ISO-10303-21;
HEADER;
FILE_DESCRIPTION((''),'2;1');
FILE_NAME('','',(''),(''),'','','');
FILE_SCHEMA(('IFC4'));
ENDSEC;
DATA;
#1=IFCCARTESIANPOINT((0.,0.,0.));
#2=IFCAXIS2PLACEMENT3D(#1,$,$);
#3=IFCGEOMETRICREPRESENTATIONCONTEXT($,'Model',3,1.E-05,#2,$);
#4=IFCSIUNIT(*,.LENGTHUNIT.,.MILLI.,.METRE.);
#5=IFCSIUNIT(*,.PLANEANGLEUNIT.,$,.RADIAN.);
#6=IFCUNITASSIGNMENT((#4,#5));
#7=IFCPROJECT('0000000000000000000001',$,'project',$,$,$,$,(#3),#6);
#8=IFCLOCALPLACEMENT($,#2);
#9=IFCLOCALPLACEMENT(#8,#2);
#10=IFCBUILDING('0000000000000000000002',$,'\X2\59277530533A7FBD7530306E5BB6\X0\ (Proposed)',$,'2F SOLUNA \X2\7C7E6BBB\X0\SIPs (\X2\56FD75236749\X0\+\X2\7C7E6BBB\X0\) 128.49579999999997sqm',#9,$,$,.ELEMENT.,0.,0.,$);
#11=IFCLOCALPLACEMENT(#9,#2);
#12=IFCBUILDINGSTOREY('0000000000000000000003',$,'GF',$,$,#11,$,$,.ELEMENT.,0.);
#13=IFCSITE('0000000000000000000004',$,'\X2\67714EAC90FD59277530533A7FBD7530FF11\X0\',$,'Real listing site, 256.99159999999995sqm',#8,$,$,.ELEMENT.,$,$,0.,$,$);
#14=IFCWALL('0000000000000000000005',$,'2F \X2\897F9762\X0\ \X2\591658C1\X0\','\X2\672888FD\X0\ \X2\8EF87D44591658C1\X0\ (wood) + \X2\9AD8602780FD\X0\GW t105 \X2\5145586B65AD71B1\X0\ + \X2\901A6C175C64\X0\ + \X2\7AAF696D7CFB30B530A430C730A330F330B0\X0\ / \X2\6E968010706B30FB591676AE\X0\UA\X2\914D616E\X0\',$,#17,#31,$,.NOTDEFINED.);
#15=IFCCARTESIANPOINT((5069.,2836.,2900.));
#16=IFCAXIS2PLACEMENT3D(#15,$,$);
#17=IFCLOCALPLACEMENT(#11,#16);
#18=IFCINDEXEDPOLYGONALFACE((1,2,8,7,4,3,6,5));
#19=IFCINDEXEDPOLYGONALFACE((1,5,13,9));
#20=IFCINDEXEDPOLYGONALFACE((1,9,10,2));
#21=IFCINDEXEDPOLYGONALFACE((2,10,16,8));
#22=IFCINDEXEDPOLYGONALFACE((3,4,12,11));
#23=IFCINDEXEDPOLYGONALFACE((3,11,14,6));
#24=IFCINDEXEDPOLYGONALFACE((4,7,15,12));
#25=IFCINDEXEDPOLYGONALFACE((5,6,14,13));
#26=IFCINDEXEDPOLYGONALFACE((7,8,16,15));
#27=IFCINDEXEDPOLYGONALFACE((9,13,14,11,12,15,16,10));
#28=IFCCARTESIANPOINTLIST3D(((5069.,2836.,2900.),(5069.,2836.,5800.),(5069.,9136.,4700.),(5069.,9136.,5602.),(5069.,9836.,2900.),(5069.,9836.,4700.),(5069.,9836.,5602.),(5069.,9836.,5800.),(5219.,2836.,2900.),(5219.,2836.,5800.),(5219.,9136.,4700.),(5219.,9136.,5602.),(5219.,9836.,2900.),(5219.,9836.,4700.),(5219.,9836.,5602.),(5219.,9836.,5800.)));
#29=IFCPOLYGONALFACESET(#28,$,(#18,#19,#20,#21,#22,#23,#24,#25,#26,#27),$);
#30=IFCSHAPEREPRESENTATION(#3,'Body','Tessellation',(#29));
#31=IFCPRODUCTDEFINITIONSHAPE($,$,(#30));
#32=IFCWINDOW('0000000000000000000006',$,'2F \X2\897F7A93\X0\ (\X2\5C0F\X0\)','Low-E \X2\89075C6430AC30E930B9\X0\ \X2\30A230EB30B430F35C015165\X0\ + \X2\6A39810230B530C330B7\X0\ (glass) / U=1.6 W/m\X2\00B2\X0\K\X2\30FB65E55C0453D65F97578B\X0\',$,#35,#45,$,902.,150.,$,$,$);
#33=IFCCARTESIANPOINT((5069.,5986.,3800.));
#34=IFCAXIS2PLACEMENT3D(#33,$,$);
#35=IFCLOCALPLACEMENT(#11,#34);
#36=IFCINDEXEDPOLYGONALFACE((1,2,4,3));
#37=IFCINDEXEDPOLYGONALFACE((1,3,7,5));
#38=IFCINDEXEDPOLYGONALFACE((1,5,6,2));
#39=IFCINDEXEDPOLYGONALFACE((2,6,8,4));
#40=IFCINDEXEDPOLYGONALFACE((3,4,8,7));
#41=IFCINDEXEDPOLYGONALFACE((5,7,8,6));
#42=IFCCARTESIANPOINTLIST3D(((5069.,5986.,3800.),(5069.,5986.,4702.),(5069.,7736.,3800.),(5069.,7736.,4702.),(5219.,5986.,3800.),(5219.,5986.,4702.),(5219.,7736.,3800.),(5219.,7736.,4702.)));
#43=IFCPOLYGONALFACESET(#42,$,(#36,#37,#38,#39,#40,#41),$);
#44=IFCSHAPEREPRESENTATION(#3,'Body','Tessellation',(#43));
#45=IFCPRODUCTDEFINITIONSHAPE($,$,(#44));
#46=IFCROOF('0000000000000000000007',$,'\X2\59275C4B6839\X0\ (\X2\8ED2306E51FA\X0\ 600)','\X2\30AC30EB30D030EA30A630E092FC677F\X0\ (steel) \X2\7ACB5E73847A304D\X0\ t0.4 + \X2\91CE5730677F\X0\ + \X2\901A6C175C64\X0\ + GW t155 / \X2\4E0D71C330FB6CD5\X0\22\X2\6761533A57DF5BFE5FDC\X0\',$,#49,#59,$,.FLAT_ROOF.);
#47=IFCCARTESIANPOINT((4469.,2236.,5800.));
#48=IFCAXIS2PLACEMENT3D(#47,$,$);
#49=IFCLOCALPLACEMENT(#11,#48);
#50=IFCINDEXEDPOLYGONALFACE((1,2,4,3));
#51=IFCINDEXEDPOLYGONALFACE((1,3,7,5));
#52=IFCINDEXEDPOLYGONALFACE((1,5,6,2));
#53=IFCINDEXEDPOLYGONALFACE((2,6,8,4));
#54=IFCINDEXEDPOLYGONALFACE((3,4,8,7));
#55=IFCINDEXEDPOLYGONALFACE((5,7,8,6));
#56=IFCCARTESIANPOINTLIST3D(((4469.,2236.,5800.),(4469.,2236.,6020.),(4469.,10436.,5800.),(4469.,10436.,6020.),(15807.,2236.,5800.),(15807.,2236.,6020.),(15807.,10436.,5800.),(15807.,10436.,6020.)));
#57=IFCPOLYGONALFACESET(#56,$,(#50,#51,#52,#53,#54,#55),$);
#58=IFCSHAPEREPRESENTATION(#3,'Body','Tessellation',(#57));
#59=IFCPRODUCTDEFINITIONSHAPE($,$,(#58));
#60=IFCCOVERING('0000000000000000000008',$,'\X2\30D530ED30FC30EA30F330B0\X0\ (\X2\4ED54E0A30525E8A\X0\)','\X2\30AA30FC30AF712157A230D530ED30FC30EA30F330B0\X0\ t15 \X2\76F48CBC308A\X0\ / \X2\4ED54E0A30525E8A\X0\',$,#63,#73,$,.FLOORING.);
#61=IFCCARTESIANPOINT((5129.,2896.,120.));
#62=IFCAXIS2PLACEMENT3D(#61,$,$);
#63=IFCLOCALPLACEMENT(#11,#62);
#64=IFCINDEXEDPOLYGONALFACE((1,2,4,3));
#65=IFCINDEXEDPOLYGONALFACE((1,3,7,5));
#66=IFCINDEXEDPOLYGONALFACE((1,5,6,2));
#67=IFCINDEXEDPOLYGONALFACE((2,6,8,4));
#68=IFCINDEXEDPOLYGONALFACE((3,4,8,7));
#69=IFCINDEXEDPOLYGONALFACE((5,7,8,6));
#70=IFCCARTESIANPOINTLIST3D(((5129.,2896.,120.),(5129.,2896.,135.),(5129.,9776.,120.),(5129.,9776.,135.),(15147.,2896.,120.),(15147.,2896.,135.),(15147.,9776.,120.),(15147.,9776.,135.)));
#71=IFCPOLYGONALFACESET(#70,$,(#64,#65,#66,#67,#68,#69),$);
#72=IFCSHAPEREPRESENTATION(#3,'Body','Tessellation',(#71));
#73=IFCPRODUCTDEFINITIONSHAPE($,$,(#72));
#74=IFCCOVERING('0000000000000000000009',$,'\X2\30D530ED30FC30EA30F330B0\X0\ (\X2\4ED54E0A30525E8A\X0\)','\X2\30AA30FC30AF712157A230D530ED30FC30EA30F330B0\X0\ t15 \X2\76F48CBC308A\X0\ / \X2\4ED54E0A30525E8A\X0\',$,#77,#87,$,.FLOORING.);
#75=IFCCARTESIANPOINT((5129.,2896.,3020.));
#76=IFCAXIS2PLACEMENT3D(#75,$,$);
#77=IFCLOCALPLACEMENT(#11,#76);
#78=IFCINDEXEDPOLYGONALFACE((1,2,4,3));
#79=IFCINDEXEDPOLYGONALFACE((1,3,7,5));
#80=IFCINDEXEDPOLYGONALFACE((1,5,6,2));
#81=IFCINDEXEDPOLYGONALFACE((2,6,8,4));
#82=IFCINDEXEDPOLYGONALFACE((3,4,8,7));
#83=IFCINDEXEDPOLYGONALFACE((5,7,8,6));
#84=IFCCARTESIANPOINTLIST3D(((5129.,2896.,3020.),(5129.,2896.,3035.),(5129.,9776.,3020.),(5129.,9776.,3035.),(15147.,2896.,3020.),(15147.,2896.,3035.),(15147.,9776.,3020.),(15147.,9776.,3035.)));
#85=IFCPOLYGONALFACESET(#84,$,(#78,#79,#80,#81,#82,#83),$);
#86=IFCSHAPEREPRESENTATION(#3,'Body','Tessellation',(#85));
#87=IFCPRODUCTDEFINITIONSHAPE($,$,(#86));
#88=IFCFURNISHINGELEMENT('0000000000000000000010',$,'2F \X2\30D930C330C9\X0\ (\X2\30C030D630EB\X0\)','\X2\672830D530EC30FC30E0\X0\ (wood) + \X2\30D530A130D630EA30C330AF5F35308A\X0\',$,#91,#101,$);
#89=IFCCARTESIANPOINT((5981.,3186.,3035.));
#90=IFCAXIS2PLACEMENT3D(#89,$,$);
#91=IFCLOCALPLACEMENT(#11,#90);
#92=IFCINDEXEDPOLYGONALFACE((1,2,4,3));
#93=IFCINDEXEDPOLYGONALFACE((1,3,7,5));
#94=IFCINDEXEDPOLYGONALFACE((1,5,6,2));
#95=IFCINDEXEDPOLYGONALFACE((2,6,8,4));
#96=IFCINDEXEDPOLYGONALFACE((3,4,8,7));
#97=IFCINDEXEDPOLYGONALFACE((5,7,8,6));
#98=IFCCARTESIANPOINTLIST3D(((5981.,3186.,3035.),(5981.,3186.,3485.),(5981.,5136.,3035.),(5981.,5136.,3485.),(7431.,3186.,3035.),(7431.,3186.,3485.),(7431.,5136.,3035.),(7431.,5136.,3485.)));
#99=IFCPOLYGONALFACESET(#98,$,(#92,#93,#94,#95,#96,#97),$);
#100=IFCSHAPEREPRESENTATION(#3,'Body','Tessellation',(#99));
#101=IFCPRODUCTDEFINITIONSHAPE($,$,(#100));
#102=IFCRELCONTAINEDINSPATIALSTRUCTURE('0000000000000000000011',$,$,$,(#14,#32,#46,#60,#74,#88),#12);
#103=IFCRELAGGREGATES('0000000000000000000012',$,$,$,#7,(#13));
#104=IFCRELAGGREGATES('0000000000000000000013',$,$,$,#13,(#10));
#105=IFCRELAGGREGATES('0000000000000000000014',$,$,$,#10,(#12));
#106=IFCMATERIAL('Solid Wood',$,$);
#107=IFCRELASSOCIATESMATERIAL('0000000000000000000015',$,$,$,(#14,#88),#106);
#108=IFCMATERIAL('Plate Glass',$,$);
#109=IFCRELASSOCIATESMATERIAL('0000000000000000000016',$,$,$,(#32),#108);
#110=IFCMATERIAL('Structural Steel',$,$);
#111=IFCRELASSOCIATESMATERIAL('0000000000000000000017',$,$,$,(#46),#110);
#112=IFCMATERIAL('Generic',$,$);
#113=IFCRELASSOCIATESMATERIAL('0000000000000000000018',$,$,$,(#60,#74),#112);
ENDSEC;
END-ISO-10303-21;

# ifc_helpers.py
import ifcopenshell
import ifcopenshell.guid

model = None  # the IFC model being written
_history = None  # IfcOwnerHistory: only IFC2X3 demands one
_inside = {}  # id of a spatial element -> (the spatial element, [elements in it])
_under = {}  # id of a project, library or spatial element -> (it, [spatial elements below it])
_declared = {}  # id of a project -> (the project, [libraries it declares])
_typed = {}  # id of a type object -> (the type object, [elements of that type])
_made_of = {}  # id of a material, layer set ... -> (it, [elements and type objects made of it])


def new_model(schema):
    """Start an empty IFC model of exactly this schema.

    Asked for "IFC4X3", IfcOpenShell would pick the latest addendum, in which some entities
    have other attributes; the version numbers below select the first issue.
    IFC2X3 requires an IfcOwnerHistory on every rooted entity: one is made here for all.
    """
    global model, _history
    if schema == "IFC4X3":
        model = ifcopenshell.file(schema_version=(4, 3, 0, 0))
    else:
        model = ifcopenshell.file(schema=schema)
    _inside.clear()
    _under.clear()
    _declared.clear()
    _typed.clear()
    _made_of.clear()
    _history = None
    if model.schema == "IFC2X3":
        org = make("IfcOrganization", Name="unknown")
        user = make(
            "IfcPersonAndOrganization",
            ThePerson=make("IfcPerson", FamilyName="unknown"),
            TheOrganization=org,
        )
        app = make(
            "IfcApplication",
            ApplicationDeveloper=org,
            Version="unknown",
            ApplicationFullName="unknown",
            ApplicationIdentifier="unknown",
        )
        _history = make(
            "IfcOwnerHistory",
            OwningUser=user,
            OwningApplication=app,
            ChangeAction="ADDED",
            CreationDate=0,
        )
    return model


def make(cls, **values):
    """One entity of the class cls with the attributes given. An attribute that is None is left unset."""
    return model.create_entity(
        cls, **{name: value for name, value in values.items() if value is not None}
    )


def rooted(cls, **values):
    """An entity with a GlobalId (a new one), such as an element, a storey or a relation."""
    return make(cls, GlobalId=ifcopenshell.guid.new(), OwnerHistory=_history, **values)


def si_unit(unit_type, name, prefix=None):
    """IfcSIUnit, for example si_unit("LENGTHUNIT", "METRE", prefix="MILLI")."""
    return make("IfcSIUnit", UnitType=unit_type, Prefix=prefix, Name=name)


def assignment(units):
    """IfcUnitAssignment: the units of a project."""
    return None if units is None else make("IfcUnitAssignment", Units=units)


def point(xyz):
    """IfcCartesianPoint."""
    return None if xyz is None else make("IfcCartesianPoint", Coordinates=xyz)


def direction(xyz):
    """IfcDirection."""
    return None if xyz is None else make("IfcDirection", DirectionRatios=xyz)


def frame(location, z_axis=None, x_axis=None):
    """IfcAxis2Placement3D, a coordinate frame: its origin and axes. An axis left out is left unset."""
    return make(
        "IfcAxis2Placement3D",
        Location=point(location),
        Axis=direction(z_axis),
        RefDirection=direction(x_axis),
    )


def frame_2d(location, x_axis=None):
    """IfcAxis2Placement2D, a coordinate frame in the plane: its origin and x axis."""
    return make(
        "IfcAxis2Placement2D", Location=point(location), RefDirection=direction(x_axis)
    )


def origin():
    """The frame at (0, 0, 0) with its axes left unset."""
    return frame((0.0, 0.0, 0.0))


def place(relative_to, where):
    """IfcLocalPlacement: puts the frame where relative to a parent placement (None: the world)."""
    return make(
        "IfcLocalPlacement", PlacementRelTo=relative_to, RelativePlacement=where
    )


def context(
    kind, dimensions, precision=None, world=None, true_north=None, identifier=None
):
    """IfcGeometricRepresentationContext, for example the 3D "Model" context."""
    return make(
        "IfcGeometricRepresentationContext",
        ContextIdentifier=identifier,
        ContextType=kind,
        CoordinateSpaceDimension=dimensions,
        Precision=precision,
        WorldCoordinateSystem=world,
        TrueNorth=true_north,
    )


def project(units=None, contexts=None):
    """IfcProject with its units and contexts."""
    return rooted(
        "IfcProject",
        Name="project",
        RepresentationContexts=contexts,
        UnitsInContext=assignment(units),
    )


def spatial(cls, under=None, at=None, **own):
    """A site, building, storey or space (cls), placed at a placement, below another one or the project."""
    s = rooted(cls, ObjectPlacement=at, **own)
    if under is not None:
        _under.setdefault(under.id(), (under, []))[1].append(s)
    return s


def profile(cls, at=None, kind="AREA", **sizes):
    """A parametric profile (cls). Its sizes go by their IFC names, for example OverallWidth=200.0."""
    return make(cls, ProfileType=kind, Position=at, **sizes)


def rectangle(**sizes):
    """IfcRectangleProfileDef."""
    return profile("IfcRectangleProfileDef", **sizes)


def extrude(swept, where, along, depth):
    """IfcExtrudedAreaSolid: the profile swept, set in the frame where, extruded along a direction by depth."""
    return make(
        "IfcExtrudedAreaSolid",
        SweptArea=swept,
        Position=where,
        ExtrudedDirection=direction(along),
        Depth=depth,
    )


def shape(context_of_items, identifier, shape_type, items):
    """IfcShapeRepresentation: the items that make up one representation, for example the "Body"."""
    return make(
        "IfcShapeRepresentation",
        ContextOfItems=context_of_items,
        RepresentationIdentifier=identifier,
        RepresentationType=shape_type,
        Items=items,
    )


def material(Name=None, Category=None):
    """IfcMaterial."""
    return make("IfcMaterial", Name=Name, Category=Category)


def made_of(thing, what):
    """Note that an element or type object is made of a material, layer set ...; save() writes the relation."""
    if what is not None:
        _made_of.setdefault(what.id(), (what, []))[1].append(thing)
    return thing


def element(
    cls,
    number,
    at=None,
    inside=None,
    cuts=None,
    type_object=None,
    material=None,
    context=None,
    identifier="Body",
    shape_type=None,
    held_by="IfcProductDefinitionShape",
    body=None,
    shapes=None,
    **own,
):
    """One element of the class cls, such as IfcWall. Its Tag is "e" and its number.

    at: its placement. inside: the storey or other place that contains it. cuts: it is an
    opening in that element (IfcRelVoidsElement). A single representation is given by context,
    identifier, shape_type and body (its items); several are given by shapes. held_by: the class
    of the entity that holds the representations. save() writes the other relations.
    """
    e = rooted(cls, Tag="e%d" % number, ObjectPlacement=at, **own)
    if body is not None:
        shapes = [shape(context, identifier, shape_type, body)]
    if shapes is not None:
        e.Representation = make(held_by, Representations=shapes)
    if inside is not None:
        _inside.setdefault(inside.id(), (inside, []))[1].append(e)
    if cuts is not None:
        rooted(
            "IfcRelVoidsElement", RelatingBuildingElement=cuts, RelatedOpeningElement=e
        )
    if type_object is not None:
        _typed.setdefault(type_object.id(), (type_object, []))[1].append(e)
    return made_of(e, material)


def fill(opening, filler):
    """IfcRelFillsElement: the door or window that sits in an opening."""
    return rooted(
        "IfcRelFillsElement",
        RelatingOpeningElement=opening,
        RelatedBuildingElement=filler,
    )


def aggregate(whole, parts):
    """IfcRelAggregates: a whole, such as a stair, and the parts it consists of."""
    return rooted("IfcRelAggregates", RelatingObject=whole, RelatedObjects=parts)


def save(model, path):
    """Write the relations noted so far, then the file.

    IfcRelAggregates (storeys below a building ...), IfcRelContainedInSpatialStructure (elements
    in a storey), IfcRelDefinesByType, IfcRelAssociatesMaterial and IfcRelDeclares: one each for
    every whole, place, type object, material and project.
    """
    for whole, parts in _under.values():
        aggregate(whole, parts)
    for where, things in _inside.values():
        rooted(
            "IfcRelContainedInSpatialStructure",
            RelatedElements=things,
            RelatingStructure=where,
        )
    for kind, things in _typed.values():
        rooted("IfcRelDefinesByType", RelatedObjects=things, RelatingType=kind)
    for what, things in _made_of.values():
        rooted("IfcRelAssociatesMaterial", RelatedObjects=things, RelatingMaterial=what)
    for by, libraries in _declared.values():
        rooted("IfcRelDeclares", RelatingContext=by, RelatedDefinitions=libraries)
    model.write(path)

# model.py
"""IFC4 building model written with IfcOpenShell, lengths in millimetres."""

from ifc_helpers import new_model, si_unit, frame, frame_2d, origin, place, context, project, spatial, rectangle, extrude, material, element, fill, save


model = new_model("IFC4")

# Units and contexts
model_context = context("Model", 3, precision=1e-05, world=origin())
ifc_project = project(units=[si_unit("LENGTHUNIT", "METRE", prefix="MILLI"), si_unit("PLANEANGLEUNIT", "RADIAN")], contexts=[model_context])

# Site, building, storey
site_placement = place(None, origin())
site = spatial("IfcSite", under=ifc_project, at=site_placement, Name="東京都大田区羽田１", ObjectType="Real listing site, 256.99159999999995sqm", CompositionType="ELEMENT", RefElevation=0.0)
building_placement = place(site_placement, origin())
building = spatial("IfcBuilding", under=site, at=building_placement, Name="大田区羽田の家 (Proposed)", ObjectType="2F SOLUNA 籾殻SIPs (国産杉+籾殻) 128.49579999999997sqm", CompositionType="ELEMENT", ElevationOfRefHeight=0.0, ElevationOfTerrain=0.0)
storey_placement = place(building_placement, origin())
storey = spatial("IfcBuildingStorey", under=building, at=storey_placement, Name="GF", CompositionType="ELEMENT", Elevation=0.0)

# Shared definitions
ifc_material_1 = material(Name="Solid Wood")

# Shared definitions
ifc_material_2 = material(Name="Plate Glass")

# Wall, opening, window
wall_1_placement = place(storey_placement, frame((5069.0, 2836.0, 2900.0)))
wall_1 = element("IfcWall", 1, at=wall_1_placement, inside=storey, material=ifc_material_1, Name="2F 西面 外壁", Description="木製 軸組外壁 (wood) + 高性能GW t105 充填断熱 + 通気層 + 窯業系サイディング / 準耐火・外皮UA配慮", PredefinedType="NOTDEFINED", context=model_context, shape_type="SweptSolid", body=[
    extrude(rectangle(XDim=150.0, YDim=7000.0, at=frame_2d((75.0, 3500.0))), frame((5069.0, 2836.0, 2900.0)), (0.0, 0.0, 1.0), 2900.0),
])
opening_1_placement = place(storey_placement, frame((5069.0, 5986.0, 3800.0)))
opening_1 = element("IfcOpeningElement", 2, at=opening_1_placement, cuts=wall_1, PredefinedType="NOTDEFINED", context=model_context, shape_type="SweptSolid", body=[
    extrude(rectangle(XDim=150.0, YDim=1750.0, at=frame_2d((75.0, 875.0))), frame((5069.0, 5986.0, 3800.0)), (0.0, 0.0, 1.0), 902.0),
])
window_1_placement = place(storey_placement, frame((5069.0, 5986.0, 3800.0)))
window_1 = element("IfcWindow", 3, at=window_1_placement, inside=storey, material=ifc_material_2, Name="2F 西窓 (小)", Description="Low-E 複層ガラス アルゴン封入 + 樹脂サッシ (glass) / U=1.6 W/m²K・日射取得型", OverallHeight=902.0, OverallWidth=150.0, context=model_context, shape_type="SweptSolid", body=[
    extrude(rectangle(XDim=150.0, YDim=1750.0, at=frame_2d((75.0, 875.0))), frame((5069.0, 5986.0, 3800.0)), (0.0, 0.0, 1.0), 902.0),
])
fill(opening_1, window_1)

# Roof
ifc_material_3 = material(Name="Structural Steel")
roof_placement = place(storey_placement, frame((4469.0, 2236.0, 5800.0)))
element("IfcRoof", 4, at=roof_placement, inside=storey, material=ifc_material_3, Name="大屋根 (軒の出 600)", Description="ガルバリウム鋼板 (steel) 立平葺き t0.4 + 野地板 + 通気層 + GW t155 / 不燃・法22条区域対応", PredefinedType="FLAT_ROOF", context=model_context, shape_type="SweptSolid", body=[
    extrude(rectangle(XDim=11338.0, YDim=8200.0, at=frame_2d((5669.0, 4100.0))), frame((4469.0, 2236.0, 5800.0)), (0.0, 0.0, 1.0), 220.0),
])

# Coverings
ifc_material_4 = material(Name="Generic")
covering_1_placement = place(storey_placement, frame((5129.0, 2896.0, 120.0)))
element("IfcCovering", 5, at=covering_1_placement, inside=storey, material=ifc_material_4, Name="フローリング (仕上げ床)", Description="オーク無垢フローリング t15 直貼り / 仕上げ床", PredefinedType="FLOORING", context=model_context, shape_type="SweptSolid", body=[
    extrude(rectangle(XDim=10018.0, YDim=6880.0, at=frame_2d((5009.0, 3440.0))), frame((5129.0, 2896.0, 120.0)), (0.0, 0.0, 1.0), 15.0),
])
covering_2_placement = place(storey_placement, frame((5129.0, 2896.0, 3020.0)))
element("IfcCovering", 6, at=covering_2_placement, inside=storey, material=ifc_material_4, Name="フローリング (仕上げ床)", Description="オーク無垢フローリング t15 直貼り / 仕上げ床", PredefinedType="FLOORING", context=model_context, shape_type="SweptSolid", body=[
    extrude(rectangle(XDim=10018.0, YDim=6880.0, at=frame_2d((5009.0, 3440.0))), frame((5129.0, 2896.0, 3020.0)), (0.0, 0.0, 1.0), 15.0),
])

# Furnishing element
furnishing_placement = place(storey_placement, frame((5981.0, 3186.0, 3035.0)))
element("IfcFurnishingElement", 7, at=furnishing_placement, inside=storey, material=ifc_material_1, Name="2F ベッド (ダブル)", Description="木フレーム (wood) + ファブリック張り", context=model_context, shape_type="SweptSolid", body=[
    extrude(rectangle(XDim=1450.0, YDim=1950.0, at=frame_2d((725.0, 975.0))), frame((5981.0, 3186.0, 3035.0)), (0.0, 0.0, 1.0), 450.0),
])

save(model, "model.ifc")
